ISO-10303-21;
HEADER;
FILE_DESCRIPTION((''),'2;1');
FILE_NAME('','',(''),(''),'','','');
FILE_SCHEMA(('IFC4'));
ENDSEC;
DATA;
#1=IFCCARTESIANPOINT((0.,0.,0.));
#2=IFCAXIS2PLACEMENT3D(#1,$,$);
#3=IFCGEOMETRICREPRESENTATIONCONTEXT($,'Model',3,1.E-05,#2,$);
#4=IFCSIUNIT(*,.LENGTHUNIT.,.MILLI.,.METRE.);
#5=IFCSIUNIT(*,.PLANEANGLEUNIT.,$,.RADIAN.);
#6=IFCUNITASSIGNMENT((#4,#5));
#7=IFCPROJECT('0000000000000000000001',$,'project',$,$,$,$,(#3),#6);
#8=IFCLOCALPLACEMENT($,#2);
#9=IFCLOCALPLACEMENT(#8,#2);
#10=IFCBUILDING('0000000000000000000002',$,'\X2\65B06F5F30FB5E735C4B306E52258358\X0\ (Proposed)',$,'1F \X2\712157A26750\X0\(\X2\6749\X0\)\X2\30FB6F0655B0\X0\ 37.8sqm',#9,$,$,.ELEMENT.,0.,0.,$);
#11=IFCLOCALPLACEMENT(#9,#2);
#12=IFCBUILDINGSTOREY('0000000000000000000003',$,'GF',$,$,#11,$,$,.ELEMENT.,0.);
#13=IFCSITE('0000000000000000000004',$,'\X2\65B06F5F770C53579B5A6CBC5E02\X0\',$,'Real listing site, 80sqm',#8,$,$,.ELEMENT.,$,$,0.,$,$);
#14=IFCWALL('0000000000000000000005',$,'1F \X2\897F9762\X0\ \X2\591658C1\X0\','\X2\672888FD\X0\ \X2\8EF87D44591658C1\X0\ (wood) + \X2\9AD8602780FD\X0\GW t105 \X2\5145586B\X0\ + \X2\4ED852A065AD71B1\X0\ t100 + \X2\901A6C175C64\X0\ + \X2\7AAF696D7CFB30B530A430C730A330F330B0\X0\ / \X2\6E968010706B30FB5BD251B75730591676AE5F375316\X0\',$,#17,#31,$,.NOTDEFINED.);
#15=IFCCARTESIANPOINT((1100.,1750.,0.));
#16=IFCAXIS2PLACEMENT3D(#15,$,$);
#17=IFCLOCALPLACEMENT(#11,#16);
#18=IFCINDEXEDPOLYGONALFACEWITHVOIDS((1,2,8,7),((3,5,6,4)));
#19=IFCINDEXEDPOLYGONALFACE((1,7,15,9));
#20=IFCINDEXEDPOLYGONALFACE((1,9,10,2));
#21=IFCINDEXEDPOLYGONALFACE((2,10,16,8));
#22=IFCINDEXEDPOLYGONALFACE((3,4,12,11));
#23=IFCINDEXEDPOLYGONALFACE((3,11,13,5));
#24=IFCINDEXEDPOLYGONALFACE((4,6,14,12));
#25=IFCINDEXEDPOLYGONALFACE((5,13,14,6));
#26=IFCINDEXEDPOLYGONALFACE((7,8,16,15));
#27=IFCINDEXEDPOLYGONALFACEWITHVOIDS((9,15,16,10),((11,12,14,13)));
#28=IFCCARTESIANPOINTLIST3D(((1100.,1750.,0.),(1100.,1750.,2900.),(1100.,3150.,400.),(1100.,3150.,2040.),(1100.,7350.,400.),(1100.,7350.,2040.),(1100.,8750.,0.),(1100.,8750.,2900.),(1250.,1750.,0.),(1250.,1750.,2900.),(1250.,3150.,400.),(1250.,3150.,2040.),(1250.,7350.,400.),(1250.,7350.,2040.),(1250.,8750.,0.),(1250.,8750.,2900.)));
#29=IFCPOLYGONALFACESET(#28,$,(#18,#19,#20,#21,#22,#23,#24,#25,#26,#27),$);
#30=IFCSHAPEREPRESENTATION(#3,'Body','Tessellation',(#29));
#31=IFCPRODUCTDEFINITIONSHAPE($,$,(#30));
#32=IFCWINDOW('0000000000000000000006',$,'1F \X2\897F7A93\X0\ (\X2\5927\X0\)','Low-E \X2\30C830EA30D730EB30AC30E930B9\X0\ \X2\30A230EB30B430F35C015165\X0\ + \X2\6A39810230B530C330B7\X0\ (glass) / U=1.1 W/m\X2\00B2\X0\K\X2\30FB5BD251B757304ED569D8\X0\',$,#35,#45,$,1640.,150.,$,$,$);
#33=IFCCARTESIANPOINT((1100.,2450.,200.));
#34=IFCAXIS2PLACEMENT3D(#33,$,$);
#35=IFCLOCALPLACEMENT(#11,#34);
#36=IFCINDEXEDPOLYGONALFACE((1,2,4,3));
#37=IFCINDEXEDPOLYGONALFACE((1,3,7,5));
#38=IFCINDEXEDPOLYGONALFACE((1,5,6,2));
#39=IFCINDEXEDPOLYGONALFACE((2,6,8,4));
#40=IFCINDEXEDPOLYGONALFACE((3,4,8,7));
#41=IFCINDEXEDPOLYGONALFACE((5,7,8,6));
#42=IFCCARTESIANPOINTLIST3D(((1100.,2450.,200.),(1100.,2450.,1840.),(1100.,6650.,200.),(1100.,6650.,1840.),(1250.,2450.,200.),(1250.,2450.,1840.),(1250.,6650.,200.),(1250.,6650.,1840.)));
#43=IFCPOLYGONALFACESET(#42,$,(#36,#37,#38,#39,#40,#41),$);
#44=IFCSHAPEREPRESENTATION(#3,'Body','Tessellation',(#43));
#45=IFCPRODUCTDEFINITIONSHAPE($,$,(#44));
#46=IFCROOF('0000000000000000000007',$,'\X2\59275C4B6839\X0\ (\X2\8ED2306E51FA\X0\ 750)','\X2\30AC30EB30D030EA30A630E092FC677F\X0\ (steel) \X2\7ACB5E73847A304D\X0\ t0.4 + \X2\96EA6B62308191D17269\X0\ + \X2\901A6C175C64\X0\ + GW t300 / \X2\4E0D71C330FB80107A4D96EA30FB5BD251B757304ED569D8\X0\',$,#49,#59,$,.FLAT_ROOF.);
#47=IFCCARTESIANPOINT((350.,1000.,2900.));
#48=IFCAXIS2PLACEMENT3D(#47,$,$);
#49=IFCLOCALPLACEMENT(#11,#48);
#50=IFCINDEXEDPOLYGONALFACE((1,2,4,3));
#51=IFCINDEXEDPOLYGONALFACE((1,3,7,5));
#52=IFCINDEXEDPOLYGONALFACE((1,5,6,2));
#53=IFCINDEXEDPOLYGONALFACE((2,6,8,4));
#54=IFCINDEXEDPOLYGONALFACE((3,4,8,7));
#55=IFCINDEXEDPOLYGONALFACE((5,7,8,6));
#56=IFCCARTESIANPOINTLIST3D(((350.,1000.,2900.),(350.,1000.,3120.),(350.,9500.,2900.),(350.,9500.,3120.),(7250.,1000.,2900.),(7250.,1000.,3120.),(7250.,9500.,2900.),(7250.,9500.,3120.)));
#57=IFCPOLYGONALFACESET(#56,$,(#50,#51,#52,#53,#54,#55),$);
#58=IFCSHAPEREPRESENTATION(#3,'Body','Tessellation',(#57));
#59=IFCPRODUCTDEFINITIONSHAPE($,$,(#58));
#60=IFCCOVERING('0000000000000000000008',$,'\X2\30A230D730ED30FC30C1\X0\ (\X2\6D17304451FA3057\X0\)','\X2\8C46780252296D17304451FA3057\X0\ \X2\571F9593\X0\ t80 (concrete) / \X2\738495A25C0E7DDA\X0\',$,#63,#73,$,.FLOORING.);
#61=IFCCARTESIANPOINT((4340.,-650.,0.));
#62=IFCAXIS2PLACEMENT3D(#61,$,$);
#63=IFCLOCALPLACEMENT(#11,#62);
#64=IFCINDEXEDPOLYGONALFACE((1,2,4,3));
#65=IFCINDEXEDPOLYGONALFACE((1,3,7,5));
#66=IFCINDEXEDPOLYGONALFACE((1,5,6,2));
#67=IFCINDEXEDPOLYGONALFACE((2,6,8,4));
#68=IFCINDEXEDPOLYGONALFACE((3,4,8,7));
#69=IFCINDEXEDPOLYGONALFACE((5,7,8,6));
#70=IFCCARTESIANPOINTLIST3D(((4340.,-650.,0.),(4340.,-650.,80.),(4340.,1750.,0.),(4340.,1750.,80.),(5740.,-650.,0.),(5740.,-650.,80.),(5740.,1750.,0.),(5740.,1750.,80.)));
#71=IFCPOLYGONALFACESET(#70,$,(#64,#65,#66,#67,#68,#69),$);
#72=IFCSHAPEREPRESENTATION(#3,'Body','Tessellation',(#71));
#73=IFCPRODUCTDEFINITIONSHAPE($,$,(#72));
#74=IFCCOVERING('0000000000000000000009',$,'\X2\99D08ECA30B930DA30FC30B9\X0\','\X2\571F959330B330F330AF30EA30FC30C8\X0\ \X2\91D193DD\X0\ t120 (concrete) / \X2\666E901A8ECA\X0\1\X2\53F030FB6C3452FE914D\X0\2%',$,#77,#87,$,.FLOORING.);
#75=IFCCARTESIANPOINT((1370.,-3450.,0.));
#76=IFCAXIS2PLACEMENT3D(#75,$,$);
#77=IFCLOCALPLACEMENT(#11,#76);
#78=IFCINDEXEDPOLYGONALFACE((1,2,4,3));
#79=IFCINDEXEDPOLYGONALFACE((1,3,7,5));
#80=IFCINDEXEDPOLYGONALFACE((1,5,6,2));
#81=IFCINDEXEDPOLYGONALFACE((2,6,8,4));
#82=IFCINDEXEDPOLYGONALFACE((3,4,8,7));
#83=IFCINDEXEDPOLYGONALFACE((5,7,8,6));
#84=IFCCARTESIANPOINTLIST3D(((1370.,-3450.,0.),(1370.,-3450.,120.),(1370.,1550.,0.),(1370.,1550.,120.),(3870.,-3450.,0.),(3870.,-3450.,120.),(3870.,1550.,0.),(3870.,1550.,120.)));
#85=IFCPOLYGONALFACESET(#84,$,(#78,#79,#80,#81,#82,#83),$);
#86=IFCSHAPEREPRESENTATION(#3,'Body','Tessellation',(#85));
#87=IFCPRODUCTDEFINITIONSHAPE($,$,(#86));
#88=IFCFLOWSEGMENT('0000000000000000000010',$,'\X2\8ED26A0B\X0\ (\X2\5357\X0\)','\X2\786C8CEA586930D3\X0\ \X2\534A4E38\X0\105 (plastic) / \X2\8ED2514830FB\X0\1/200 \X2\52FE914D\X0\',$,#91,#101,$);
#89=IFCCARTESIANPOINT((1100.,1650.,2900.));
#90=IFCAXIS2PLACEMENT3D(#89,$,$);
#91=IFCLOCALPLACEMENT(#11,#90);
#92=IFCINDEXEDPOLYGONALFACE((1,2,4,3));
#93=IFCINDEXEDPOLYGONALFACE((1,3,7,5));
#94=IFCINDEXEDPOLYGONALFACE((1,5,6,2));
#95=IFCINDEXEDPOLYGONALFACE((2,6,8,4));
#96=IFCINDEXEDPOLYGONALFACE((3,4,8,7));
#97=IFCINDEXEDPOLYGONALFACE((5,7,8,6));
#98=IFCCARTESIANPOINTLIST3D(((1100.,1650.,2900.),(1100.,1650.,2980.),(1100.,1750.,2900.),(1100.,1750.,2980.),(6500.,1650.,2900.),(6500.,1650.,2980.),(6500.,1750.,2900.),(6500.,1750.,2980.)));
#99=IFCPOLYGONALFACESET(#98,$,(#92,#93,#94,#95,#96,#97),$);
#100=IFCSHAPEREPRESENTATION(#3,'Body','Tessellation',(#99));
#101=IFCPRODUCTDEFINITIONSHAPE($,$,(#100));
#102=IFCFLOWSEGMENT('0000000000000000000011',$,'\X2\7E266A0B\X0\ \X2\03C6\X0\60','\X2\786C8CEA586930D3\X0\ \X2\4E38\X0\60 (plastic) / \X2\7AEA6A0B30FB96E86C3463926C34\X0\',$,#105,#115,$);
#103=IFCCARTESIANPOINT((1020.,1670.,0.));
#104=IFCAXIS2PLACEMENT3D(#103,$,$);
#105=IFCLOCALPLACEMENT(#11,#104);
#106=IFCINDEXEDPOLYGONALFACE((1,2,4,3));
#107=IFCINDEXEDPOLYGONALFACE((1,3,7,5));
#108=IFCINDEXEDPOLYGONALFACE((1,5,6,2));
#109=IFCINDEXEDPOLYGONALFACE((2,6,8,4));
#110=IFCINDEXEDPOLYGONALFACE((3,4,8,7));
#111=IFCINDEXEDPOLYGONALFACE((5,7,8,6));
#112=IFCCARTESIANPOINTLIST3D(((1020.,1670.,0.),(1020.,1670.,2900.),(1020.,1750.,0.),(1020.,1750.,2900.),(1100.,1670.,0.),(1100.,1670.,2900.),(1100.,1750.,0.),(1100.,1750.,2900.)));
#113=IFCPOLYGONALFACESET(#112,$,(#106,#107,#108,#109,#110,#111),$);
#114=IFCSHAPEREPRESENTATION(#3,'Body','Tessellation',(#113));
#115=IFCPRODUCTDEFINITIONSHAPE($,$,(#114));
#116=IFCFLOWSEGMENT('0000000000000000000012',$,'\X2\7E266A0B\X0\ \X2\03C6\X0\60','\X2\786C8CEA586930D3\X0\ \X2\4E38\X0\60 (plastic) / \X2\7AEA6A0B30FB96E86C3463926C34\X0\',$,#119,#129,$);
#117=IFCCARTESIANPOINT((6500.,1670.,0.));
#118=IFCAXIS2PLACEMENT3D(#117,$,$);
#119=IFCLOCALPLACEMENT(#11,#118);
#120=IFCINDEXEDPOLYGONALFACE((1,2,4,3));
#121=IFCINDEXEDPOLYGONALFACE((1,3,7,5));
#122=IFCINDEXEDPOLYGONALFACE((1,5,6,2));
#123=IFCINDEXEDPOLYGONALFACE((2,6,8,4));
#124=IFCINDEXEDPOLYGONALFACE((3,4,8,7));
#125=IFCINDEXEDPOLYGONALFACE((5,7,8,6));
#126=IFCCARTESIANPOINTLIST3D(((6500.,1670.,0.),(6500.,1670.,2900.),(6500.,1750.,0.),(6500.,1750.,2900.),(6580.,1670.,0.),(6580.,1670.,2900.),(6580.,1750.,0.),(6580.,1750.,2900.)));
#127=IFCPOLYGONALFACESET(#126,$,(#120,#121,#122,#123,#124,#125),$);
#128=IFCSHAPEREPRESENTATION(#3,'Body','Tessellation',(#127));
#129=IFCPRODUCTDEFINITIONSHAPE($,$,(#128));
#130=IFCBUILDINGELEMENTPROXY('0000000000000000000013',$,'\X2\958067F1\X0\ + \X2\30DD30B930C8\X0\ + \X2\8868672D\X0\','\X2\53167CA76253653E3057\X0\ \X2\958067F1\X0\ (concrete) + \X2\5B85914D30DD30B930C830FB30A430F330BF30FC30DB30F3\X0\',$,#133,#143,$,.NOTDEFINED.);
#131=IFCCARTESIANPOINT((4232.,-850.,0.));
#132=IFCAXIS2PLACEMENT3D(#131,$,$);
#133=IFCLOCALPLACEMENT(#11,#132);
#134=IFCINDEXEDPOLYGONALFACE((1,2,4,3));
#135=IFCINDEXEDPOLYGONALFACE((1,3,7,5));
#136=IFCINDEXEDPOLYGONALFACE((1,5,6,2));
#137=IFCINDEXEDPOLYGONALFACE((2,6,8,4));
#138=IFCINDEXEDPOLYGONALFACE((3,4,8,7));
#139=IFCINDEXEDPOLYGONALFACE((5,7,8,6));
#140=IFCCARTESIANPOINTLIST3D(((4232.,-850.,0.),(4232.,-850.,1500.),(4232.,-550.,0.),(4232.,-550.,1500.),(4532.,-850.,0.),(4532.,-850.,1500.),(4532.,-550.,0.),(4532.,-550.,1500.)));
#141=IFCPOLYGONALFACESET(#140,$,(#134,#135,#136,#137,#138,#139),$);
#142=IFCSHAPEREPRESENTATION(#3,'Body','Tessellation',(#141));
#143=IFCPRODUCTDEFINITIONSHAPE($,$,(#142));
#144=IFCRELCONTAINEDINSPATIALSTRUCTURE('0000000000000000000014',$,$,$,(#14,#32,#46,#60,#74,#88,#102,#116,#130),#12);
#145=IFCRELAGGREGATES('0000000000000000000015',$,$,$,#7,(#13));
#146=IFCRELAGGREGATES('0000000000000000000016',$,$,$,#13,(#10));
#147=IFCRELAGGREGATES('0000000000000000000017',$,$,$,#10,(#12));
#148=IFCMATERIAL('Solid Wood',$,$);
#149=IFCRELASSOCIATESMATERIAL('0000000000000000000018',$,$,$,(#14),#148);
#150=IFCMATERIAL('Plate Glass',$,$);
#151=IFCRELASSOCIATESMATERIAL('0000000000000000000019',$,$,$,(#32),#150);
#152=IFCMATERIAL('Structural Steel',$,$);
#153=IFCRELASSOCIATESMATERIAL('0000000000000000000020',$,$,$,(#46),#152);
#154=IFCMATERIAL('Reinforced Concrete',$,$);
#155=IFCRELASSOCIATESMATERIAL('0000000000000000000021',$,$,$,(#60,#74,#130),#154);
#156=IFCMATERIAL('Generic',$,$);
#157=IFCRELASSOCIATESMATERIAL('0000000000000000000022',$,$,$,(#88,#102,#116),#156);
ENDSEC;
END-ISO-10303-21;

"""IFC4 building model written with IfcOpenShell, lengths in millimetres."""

from ifc_helpers import new_model, si_unit, frame, frame_2d, origin, place, context, project, spatial, rectangle, extrude, material, element, fill, save


model = new_model("IFC4")

# Units and contexts
model_context = context("Model", 3, precision=1e-05, world=origin())
ifc_project = project(units=[si_unit("LENGTHUNIT", "METRE", prefix="MILLI"), si_unit("PLANEANGLEUNIT", "RADIAN")], contexts=[model_context])

# Site, building, storey
site_placement = place(None, origin())
site = spatial("IfcSite", under=ifc_project, at=site_placement, Name="新潟県南魚沼市", ObjectType="Real listing site, 80sqm", CompositionType="ELEMENT", RefElevation=0.0)
building_placement = place(site_placement, origin())
building = spatial("IfcBuilding", under=site, at=building_placement, Name="新潟・平屋の別荘 (Proposed)", ObjectType="1F 無垢材(杉)・漆喰 37.8sqm", CompositionType="ELEMENT", ElevationOfRefHeight=0.0, ElevationOfTerrain=0.0)
storey_placement = place(building_placement, origin())
storey = spatial("IfcBuildingStorey", under=building, at=storey_placement, Name="GF", CompositionType="ELEMENT", Elevation=0.0)

# Shared definitions
ifc_material_1 = material(Name="Solid Wood")

# Shared definitions
ifc_material_2 = material(Name="Reinforced Concrete")

# Shared definitions
ifc_material_3 = material(Name="Plate Glass")

# Wall, opening, window
wall_1_placement = place(storey_placement, frame((1100.0, 1750.0, 0.0)))
wall_1 = element("IfcWall", 1, at=wall_1_placement, inside=storey, material=ifc_material_1, Name="1F 西面 外壁", Description="木製 軸組外壁 (wood) + 高性能GW t105 充填 + 付加断熱 t100 + 通気層 + 窯業系サイディング / 準耐火・寒冷地外皮強化", PredefinedType="NOTDEFINED", context=model_context, shape_type="SweptSolid", body=[
    extrude(rectangle(XDim=150.0, YDim=7000.0, at=frame_2d((75.0, 3500.0))), frame((1100.0, 1750.0, 0.0)), (0.0, 0.0, 1.0), 2900.0),
])
opening_1_placement = place(storey_placement, frame((1100.0, 2450.0, 200.0)))
opening_1 = element("IfcOpeningElement", 2, at=opening_1_placement, cuts=wall_1, PredefinedType="NOTDEFINED", context=model_context, shape_type="SweptSolid", body=[
    extrude(rectangle(XDim=150.0, YDim=4200.0, at=frame_2d((75.0, 2100.0))), frame((1100.0, 2450.0, 200.0)), (0.0, 0.0, 1.0), 1640.0),
])
window_1_placement = place(storey_placement, frame((1100.0, 2450.0, 200.0)))
window_1 = element("IfcWindow", 3, at=window_1_placement, inside=storey, material=ifc_material_3, Name="1F 西窓 (大)", Description="Low-E トリプルガラス アルゴン封入 + 樹脂サッシ (glass) / U=1.1 W/m²K・寒冷地仕様", OverallHeight=1640.0, OverallWidth=150.0, context=model_context, shape_type="SweptSolid", body=[
    extrude(rectangle(XDim=150.0, YDim=4200.0, at=frame_2d((75.0, 2100.0))), frame((1100.0, 2450.0, 200.0)), (0.0, 0.0, 1.0), 1640.0),
])
fill(opening_1, window_1)

# Roof
ifc_material_4 = material(Name="Structural Steel")
roof_placement = place(storey_placement, frame((350.0, 1000.0, 2900.0)))
element("IfcRoof", 4, at=roof_placement, inside=storey, material=ifc_material_4, Name="大屋根 (軒の出 750)", Description="ガルバリウム鋼板 (steel) 立平葺き t0.4 + 雪止め金物 + 通気層 + GW t300 / 不燃・耐積雪・寒冷地仕様", PredefinedType="FLAT_ROOF", context=model_context, shape_type="SweptSolid", body=[
    extrude(rectangle(XDim=6900.0, YDim=8500.0, at=frame_2d((3450.0, 4250.0))), frame((350.0, 1000.0, 2900.0)), (0.0, 0.0, 1.0), 220.0),
])

# Coverings
covering_1_placement = place(storey_placement, frame((4340.0, -650.0, 0.0)))
element("IfcCovering", 5, at=covering_1_placement, inside=storey, material=ifc_material_2, Name="アプローチ (洗い出し)", Description="豆砂利洗い出し 土間 t80 (concrete) / 玄関導線", PredefinedType="FLOORING", context=model_context, shape_type="SweptSolid", body=[
    extrude(rectangle(XDim=1400.0, YDim=2400.0, at=frame_2d((700.0, 1200.0))), frame((4340.0, -650.0, 0.0)), (0.0, 0.0, 1.0), 80.0),
])
covering_2_placement = place(storey_placement, frame((1370.0, -3450.0, 0.0)))
element("IfcCovering", 6, at=covering_2_placement, inside=storey, material=ifc_material_2, Name="駐車スペース", Description="土間コンクリート 金鏝 t120 (concrete) / 普通車1台・水勾配2%", PredefinedType="FLOORING", context=model_context, shape_type="SweptSolid", body=[
    extrude(rectangle(XDim=2500.0, YDim=5000.0, at=frame_2d((1250.0, 2500.0))), frame((1370.0, -3450.0, 0.0)), (0.0, 0.0, 1.0), 120.0),
])

# Flow segments
ifc_material_5 = material(Name="Generic")
flow_segment_1_placement = place(storey_placement, frame((1100.0, 1650.0, 2900.0)))
element("IfcFlowSegment", 7, at=flow_segment_1_placement, inside=storey, material=ifc_material_5, Name="軒樋 (南)", Description="硬質塩ビ 半丸105 (plastic) / 軒先・1/200 勾配", context=model_context, shape_type="SweptSolid", body=[
    extrude(rectangle(XDim=5400.0, YDim=100.0, at=frame_2d((2700.0, 50.0))), frame((1100.0, 1650.0, 2900.0)), (0.0, 0.0, 1.0), 80.0),
])
flow_segment_2_placement = place(storey_placement, frame((1020.0, 1670.0, 0.0)))
element("IfcFlowSegment", 8, at=flow_segment_2_placement, inside=storey, material=ifc_material_5, Name="縦樋 φ60", Description="硬質塩ビ 丸60 (plastic) / 竪樋・雨水排水", context=model_context, shape_type="SweptSolid", body=[
    extrude(rectangle(XDim=80.0, YDim=80.0, at=frame_2d((40.0, 40.0))), frame((1020.0, 1670.0, 0.0)), (0.0, 0.0, 1.0), 2900.0),
])
flow_segment_3_placement = place(storey_placement, frame((6500.0, 1670.0, 0.0)))
element("IfcFlowSegment", 9, at=flow_segment_3_placement, inside=storey, material=ifc_material_5, Name="縦樋 φ60", Description="硬質塩ビ 丸60 (plastic) / 竪樋・雨水排水", context=model_context, shape_type="SweptSolid", body=[
    extrude(rectangle(XDim=80.0, YDim=80.0, at=frame_2d((40.0, 40.0))), frame((6500.0, 1670.0, 0.0)), (0.0, 0.0, 1.0), 2900.0),
])

# Building element proxy
proxy_placement = place(storey_placement, frame((4232.0, -850.0, 0.0)))
element("IfcBuildingElementProxy", 10, at=proxy_placement, inside=storey, material=ifc_material_2, Name="門柱 + ポスト + 表札", Description="化粧打放し 門柱 (concrete) + 宅配ポスト・インターホン", PredefinedType="NOTDEFINED", context=model_context, shape_type="SweptSolid", body=[
    extrude(rectangle(XDim=300.0, YDim=300.0, at=frame_2d((150.0, 150.0))), frame((4232.0, -850.0, 0.0)), (0.0, 0.0, 1.0), 1500.0),
])

save(model, "model.ifc")
